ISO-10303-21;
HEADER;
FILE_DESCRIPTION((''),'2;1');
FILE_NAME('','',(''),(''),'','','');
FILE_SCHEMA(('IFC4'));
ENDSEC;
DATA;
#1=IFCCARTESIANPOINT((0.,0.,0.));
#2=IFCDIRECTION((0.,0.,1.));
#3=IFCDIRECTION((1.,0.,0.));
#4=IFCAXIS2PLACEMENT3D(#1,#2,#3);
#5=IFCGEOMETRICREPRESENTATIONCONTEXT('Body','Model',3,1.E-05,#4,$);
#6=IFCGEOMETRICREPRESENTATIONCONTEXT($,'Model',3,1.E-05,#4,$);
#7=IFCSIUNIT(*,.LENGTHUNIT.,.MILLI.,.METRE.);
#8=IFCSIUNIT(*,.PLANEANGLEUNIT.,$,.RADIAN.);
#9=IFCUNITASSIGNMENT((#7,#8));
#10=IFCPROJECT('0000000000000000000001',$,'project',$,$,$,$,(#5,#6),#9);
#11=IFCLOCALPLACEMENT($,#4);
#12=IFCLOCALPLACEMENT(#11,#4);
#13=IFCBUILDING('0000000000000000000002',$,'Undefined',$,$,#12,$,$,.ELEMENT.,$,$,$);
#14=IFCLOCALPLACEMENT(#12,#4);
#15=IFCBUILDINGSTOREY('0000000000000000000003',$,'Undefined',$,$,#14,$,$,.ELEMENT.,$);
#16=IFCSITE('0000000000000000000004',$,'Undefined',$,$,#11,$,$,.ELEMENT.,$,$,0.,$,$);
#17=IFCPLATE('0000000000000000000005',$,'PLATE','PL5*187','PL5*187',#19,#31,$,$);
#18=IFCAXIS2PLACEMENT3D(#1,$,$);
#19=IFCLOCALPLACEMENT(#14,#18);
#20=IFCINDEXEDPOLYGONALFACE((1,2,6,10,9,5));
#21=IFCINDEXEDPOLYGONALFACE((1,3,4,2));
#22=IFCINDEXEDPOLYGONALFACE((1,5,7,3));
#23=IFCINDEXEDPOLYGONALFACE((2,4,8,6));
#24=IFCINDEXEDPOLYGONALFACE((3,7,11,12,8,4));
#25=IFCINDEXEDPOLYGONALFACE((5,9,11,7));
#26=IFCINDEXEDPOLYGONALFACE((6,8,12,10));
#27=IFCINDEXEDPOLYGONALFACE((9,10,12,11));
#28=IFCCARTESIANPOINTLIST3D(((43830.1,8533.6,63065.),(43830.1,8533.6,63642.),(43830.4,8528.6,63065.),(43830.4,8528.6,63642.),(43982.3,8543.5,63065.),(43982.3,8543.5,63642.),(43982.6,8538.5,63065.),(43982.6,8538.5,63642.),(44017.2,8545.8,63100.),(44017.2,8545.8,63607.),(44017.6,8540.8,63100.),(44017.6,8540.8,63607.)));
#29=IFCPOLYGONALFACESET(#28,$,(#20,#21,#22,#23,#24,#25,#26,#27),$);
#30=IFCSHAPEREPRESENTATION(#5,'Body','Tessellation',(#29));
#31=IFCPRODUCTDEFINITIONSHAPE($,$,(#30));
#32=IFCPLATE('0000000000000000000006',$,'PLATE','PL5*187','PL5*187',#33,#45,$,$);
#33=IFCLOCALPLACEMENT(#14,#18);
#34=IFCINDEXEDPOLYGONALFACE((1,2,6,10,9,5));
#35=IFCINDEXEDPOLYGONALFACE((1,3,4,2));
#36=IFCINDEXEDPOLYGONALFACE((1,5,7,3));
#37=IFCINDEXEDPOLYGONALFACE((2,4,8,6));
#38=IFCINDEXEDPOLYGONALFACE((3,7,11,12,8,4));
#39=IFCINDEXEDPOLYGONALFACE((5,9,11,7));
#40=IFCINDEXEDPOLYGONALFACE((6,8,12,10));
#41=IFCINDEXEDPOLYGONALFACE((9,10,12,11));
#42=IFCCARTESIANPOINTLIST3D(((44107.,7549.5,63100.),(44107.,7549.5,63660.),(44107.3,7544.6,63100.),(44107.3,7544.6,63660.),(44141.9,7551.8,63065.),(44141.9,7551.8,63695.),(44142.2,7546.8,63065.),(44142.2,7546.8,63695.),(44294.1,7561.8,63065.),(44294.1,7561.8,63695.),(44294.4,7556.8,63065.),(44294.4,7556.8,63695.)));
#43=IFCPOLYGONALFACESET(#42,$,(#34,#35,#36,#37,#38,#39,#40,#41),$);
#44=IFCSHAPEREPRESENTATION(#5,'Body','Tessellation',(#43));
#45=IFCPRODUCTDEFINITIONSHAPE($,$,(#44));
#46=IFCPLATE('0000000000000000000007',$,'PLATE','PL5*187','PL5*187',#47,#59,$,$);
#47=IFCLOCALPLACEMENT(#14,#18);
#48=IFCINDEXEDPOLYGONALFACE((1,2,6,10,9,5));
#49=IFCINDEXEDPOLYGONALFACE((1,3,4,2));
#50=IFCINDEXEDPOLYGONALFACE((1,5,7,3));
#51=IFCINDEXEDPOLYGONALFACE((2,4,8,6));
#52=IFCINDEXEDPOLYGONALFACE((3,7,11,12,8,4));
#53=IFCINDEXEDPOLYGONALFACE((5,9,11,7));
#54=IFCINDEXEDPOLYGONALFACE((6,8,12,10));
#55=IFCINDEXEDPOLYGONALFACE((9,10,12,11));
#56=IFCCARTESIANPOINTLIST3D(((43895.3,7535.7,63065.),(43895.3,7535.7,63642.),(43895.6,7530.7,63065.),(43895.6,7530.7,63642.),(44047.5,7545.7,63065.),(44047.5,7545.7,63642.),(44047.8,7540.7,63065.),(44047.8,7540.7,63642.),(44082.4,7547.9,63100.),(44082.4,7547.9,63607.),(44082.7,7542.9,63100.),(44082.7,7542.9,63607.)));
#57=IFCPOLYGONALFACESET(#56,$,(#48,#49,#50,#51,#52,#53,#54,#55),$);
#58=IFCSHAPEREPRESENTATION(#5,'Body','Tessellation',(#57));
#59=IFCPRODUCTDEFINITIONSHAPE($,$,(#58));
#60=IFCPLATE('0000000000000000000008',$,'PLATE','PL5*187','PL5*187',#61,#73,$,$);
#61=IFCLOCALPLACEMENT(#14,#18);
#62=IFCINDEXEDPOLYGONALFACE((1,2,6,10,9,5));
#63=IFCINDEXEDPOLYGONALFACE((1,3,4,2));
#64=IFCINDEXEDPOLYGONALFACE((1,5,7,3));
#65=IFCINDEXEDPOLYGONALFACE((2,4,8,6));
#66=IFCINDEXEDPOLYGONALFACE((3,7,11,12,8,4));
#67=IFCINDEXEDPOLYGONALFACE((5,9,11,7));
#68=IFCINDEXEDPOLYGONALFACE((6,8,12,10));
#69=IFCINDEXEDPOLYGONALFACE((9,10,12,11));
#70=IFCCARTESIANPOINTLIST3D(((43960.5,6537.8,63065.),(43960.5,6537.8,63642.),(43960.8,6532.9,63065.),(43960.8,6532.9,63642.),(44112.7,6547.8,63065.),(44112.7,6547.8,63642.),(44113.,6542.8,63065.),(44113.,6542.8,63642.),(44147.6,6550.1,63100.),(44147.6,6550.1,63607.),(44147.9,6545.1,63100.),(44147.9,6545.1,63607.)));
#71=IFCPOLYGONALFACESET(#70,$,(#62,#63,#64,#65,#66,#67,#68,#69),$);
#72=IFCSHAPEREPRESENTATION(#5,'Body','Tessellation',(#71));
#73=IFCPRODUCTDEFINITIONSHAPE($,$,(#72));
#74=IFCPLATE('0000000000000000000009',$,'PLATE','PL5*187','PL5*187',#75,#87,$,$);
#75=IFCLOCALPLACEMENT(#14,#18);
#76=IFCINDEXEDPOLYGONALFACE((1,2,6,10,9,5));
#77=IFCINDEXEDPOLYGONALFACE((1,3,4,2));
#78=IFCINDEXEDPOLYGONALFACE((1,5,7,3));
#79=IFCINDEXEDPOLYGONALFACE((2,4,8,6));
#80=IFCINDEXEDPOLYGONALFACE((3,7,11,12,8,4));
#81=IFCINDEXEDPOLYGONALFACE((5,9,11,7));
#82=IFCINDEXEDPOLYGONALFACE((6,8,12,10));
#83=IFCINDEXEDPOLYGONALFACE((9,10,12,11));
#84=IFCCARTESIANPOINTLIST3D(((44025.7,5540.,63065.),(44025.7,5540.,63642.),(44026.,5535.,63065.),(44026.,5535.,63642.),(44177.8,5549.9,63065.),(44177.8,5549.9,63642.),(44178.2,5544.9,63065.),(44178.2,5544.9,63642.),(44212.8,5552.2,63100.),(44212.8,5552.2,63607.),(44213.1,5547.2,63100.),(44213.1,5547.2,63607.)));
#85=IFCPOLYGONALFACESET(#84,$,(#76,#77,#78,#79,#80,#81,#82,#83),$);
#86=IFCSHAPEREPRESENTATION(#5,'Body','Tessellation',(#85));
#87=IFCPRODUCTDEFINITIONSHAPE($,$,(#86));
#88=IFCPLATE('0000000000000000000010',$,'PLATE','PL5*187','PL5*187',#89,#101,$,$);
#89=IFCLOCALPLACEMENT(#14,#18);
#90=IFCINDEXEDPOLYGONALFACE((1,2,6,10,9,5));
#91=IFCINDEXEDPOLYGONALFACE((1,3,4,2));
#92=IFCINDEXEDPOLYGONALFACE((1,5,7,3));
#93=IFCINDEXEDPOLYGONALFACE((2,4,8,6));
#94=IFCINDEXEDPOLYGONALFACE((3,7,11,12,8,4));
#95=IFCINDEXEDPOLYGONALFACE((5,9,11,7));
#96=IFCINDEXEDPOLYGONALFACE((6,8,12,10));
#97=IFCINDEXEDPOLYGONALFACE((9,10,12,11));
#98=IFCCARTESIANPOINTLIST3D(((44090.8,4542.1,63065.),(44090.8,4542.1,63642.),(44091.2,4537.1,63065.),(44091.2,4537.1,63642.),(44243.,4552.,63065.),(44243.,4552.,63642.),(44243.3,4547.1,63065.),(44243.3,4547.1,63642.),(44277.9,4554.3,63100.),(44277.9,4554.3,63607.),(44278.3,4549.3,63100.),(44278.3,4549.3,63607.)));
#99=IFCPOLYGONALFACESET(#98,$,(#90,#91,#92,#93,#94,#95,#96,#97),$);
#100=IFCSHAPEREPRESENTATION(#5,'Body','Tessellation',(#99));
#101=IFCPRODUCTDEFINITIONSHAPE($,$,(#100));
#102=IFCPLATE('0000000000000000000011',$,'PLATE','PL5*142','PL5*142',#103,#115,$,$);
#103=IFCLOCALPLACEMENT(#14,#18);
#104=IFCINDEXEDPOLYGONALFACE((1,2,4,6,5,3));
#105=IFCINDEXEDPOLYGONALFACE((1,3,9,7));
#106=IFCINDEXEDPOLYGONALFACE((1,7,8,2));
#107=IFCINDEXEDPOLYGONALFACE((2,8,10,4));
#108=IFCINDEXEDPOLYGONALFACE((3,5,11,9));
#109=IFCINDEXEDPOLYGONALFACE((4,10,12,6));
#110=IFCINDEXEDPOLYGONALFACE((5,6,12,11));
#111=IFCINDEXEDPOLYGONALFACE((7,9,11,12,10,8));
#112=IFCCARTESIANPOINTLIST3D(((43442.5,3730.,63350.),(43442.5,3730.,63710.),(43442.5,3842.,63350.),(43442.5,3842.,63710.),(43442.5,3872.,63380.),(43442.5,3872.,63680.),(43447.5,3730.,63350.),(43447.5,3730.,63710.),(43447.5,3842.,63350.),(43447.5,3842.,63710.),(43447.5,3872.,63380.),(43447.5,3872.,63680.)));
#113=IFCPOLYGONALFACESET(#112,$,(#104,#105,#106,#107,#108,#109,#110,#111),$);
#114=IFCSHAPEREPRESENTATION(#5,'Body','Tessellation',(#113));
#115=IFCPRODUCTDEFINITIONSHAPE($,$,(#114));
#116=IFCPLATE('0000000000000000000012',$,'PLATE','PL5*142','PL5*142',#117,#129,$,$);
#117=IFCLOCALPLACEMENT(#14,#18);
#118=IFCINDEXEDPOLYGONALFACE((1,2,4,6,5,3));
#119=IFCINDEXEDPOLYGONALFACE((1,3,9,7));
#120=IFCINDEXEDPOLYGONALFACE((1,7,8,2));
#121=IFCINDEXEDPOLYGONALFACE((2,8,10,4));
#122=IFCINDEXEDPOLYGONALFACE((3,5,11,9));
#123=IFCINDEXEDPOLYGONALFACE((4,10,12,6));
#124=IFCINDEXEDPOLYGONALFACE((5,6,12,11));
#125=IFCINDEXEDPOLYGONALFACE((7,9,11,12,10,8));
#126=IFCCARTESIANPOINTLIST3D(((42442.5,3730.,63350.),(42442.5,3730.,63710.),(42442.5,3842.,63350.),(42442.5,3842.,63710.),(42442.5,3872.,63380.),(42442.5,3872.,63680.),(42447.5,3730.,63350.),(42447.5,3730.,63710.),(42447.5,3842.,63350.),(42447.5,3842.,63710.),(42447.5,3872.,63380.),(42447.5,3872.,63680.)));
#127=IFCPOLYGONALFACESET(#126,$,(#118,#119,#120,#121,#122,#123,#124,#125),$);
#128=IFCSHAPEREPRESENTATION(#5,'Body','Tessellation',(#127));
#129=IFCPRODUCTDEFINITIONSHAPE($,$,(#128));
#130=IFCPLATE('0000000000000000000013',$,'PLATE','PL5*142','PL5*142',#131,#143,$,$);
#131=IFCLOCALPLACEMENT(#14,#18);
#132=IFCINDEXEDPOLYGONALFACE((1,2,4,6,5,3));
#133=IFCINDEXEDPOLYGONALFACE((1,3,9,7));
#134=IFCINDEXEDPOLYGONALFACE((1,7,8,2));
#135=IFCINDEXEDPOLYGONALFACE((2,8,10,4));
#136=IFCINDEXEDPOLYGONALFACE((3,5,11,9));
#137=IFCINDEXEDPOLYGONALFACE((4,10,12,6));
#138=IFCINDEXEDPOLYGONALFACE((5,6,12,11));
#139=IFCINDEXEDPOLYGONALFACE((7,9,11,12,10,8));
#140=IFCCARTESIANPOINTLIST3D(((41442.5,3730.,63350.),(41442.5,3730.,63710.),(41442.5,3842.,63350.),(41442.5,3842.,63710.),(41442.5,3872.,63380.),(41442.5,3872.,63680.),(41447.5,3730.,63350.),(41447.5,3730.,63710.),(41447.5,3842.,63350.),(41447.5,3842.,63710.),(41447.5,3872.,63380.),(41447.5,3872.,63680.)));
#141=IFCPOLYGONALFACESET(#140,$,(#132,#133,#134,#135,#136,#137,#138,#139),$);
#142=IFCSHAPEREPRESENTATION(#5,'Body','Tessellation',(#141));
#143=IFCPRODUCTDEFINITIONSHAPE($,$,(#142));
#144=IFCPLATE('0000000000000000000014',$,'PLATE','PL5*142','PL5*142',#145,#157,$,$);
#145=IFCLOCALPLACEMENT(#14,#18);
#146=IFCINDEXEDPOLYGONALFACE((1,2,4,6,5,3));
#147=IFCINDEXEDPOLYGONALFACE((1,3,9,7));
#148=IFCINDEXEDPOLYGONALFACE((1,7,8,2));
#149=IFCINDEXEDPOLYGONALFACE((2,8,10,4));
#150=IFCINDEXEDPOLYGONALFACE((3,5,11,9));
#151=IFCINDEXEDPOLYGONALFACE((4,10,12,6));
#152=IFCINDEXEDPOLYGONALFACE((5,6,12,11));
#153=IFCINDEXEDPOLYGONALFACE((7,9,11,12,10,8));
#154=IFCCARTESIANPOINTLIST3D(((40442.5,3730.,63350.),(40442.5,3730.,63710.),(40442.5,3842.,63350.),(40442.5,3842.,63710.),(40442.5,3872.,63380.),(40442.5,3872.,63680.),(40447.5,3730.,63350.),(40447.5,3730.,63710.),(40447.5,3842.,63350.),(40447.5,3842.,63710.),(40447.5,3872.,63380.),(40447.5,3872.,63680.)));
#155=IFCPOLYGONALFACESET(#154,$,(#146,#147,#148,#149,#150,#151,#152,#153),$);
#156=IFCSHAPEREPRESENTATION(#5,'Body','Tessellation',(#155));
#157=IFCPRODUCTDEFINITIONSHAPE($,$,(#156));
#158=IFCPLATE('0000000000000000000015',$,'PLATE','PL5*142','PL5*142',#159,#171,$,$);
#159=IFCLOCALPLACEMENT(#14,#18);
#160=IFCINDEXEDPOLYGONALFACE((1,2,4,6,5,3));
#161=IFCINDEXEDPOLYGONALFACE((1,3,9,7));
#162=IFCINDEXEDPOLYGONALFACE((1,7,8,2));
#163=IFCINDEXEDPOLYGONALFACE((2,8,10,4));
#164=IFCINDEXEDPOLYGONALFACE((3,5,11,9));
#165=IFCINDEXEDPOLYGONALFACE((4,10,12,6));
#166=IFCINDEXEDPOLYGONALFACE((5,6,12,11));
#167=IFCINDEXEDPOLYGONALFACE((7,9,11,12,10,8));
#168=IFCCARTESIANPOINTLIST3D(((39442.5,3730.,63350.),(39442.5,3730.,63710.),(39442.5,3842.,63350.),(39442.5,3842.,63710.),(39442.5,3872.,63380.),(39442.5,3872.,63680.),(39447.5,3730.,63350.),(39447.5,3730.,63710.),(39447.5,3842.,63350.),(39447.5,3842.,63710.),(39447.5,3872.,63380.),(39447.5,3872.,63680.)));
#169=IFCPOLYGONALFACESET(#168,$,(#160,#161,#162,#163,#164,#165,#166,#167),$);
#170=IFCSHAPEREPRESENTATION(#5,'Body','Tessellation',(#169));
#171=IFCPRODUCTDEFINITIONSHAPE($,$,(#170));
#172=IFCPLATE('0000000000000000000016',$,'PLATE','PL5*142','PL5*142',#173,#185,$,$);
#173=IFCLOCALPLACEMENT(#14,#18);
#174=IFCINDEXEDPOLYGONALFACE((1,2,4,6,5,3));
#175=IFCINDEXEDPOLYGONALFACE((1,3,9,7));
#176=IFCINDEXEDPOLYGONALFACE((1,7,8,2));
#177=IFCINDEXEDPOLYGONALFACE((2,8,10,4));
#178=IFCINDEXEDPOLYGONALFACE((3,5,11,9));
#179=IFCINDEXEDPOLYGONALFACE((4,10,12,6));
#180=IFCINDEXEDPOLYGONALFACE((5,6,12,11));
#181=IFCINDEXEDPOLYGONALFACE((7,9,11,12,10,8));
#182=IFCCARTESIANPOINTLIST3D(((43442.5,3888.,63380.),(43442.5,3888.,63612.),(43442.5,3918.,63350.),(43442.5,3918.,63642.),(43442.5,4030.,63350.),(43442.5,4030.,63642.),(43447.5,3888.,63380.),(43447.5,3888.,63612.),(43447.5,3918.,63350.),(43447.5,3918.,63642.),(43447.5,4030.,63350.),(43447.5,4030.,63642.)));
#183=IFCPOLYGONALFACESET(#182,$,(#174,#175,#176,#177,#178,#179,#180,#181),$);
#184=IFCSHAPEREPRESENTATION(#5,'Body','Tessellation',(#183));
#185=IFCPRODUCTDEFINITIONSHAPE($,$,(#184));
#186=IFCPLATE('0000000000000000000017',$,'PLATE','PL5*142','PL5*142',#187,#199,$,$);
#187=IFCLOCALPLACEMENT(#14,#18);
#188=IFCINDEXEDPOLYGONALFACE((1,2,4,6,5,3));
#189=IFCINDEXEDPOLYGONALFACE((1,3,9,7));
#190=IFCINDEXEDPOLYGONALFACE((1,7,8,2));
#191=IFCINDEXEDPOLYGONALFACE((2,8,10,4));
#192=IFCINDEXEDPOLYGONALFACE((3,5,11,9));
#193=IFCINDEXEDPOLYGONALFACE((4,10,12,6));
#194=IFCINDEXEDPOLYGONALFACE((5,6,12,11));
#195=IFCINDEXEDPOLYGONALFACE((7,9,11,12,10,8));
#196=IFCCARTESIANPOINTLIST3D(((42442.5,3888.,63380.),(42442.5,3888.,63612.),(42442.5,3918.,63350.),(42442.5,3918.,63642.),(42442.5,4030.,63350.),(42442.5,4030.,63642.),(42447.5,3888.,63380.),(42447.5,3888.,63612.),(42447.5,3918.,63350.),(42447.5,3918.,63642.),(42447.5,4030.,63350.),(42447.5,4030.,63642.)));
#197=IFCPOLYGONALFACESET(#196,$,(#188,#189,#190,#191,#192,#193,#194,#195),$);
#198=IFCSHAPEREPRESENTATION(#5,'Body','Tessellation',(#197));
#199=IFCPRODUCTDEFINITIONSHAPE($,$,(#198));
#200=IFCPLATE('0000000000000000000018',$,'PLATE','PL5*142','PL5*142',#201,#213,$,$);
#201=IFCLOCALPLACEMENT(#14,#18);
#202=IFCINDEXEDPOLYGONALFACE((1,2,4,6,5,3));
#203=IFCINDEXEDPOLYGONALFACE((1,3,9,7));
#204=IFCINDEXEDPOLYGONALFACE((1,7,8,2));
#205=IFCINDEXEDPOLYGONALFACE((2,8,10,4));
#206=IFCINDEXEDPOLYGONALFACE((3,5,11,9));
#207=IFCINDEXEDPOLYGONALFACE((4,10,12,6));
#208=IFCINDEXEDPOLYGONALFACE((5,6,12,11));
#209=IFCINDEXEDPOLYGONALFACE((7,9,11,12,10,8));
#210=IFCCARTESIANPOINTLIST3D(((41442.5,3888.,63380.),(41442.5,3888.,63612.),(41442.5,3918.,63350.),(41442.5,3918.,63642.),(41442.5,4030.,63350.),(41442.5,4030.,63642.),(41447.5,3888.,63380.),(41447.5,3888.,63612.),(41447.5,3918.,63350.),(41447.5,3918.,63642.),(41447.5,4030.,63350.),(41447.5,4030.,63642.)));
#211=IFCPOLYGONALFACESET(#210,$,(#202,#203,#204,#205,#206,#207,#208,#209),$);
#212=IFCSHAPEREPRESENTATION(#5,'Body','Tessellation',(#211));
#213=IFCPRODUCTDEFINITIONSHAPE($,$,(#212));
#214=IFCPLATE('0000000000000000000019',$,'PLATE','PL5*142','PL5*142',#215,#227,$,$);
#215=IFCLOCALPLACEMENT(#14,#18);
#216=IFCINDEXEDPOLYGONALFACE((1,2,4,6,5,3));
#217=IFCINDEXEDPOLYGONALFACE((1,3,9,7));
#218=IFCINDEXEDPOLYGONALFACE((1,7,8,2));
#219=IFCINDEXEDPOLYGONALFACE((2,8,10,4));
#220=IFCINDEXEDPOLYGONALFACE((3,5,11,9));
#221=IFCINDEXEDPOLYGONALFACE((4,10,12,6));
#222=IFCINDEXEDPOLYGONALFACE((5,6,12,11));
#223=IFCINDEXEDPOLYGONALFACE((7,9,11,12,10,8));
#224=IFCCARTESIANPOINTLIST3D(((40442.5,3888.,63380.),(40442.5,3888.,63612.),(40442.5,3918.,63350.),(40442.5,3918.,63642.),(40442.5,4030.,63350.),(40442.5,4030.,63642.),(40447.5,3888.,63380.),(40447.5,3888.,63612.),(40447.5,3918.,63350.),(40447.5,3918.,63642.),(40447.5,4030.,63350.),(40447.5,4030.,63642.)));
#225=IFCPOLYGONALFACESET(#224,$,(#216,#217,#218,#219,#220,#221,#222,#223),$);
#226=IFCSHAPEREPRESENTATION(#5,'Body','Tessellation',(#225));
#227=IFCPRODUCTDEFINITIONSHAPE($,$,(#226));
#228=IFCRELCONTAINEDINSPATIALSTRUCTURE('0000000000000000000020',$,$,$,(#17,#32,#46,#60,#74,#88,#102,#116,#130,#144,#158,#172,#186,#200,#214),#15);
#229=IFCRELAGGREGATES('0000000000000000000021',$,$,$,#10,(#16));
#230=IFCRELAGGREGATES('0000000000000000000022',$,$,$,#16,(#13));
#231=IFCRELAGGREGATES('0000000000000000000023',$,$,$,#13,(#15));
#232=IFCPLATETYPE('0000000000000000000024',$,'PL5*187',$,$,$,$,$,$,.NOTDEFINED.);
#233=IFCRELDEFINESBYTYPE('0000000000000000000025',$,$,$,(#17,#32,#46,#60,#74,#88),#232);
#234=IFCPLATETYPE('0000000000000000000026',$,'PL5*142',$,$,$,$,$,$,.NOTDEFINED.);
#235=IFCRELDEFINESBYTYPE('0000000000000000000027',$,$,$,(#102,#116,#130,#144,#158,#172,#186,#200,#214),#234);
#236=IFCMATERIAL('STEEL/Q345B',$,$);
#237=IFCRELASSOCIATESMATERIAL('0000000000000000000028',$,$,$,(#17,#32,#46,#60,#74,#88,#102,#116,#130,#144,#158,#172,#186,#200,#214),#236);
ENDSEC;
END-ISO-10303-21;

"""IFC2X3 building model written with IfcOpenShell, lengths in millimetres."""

from ifc_helpers import new_model, si_unit, frame, origin_with_axes, place, context, project, spatial, polyline, outline, extrude, material, type_object, element, save


model = new_model("IFC2X3")

# Units and contexts
model_context_1 = context("Model", 3, precision=1e-05, world=origin_with_axes(), identifier="Body")
model_context_2 = context("Model", 3, precision=1e-05, world=origin_with_axes())
ifc_project = project(units=[si_unit("LENGTHUNIT", "METRE", prefix="MILLI"), si_unit("PLANEANGLEUNIT", "RADIAN")], contexts=[model_context_1, model_context_2])

# Site, building, storey
site_placement = place(None, origin_with_axes())
site = spatial("IfcSite", under=ifc_project, at=site_placement, Name="Undefined", CompositionType="ELEMENT", RefElevation=0.0)
building_placement = place(site_placement, origin_with_axes())
building = spatial("IfcBuilding", under=site, at=building_placement, Name="Undefined", CompositionType="ELEMENT")
storey_placement = place(building_placement, origin_with_axes())
storey = spatial("IfcBuildingStorey", under=building, at=storey_placement, Name="Undefined", CompositionType="ELEMENT")

# Shared definitions
ifc_material_1 = material(Name="STEEL/Q345B")

# Plates
plate_type_1 = type_object("IfcPlateType", Name="PL5*187", PredefinedType="NOTDEFINED")
plate_1_placement = place(storey_placement, frame((43830.3, 8531.1, 63642.0), z_axis=(-0.065184, 0.997873, 0.0), x_axis=(0.997873, 0.065184, 0.0)))
element("IfcPlate", 1, at=plate_1_placement, inside=storey, type_object=plate_type_1, material=ifc_material_1, Name="PLATE", Description="PL5*187", ObjectType="PL5*187", context=model_context_1, shape_type="SweptSolid", body=[
    extrude(outline(polyline([(0.0, 0.0), (152.5, 0.0), (187.5, 35.0), (187.5, 542.0), (152.5, 577.0), (0.0, 577.0), (0.0, 0.0)])), frame((0.0, 0.0, -2.5), z_axis=(0.0, 0.0, 1.0), x_axis=(1.0, 0.0, 0.0)), (0.0, 0.0, 1.0), 5.0),
])
plate_2_placement = place(storey_placement, frame((44294.3, 7559.3, 63695.0), z_axis=(0.065171, -0.997874, 0.0), x_axis=(-0.997874, -0.065171, 0.0)))
element("IfcPlate", 2, at=plate_2_placement, inside=storey, type_object=plate_type_1, material=ifc_material_1, Name="PLATE", Description="PL5*187", ObjectType="PL5*187", context=model_context_1, shape_type="SweptSolid", body=[
    extrude(outline(polyline([(0.0, 0.0), (152.5, 0.0), (187.5, 35.0), (187.5, 595.0), (152.5, 630.0), (0.0, 630.0), (0.0, 0.0)])), frame((0.0, 0.0, -2.5), z_axis=(0.0, 0.0, 1.0), x_axis=(1.0, 0.0, 0.0)), (0.0, 0.0, 1.0), 5.0),
])
for number, where, z_axis, x_axis, name in (
    (3, (43895.5, 7533.2, 63642.0), (-0.065184, 0.997873, 0.0), (0.997873, 0.065184, 0.0), "PLATE"),
    (4, (43960.6, 6535.4, 63642.0), (-0.065184, 0.997873, 0.0), (0.997873, 0.065184, 0.0), "PLATE"),
    (5, (44025.8, 5537.5, 63642.0), (-0.065184, 0.997873, 0.0), (0.997873, 0.065184, 0.0), "PLATE"),
    (6, (44091.0, 4539.6, 63642.0), (-0.065184, 0.997873, 0.0), (0.997873, 0.065184, 0.0), "PLATE"),
):
    element("IfcPlate", number, at=place(storey_placement, frame(where, z_axis=z_axis, x_axis=x_axis)), inside=storey, type_object=plate_type_1, material=ifc_material_1, Name=name, Description="PL5*187", ObjectType="PL5*187", context=model_context_1, shape_type="SweptSolid", body=[
        extrude(outline(polyline([(0.0, 0.0), (152.5, 0.0), (187.5, 35.0), (187.5, 542.0), (152.5, 577.0), (0.0, 577.0), (0.0, 0.0)])), frame((0.0, 0.0, -2.5), z_axis=(0.0, 0.0, 1.0), x_axis=(1.0, 0.0, 0.0)), (0.0, 0.0, 1.0), 5.0),
    ])
plate_type_2 = type_object("IfcPlateType", Name="PL5*142", PredefinedType="NOTDEFINED")
for number, where, z_axis, x_axis, name in (
    (7, (43445.0, 3730.0, 63710.0), (-1.0, 0.0, 0.0), (0.0, 1.0, 0.0), "PLATE"),
    (8, (42445.0, 3730.0, 63710.0), (-1.0, 0.0, 0.0), (0.0, 1.0, 0.0), "PLATE"),
    (9, (41445.0, 3730.0, 63710.0), (-1.0, 0.0, 0.0), (0.0, 1.0, 0.0), "PLATE"),
    (10, (40445.0, 3730.0, 63710.0), (-1.0, 0.0, 0.0), (0.0, 1.0, 0.0), "PLATE"),
    (11, (39445.0, 3730.0, 63710.0), (-1.0, 0.0, 0.0), (0.0, 1.0, 0.0), "PLATE"),
):
    element("IfcPlate", number, at=place(storey_placement, frame(where, z_axis=z_axis, x_axis=x_axis)), inside=storey, type_object=plate_type_2, material=ifc_material_1, Name=name, Description="PL5*142", ObjectType="PL5*142", context=model_context_1, shape_type="SweptSolid", body=[
        extrude(outline(polyline([(0.0, 0.0), (112.0, 0.0), (142.0, 30.0), (142.0, 330.0), (112.0, 360.0), (0.0, 360.0), (0.0, 0.0)])), frame((0.0, 0.0, -2.5), z_axis=(0.0, 0.0, 1.0), x_axis=(1.0, 0.0, 0.0)), (0.0, 0.0, 1.0), 5.0),
    ])
for number, where, z_axis, x_axis, name in (
    (12, (43445.0, 4030.0, 63642.0), (1.0, 0.0, 0.0), (0.0, -1.0, 0.0), "PLATE"),
    (13, (42445.0, 4030.0, 63642.0), (1.0, 0.0, 0.0), (0.0, -1.0, 0.0), "PLATE"),
    (14, (41445.0, 4030.0, 63642.0), (1.0, 0.0, 0.0), (0.0, -1.0, 0.0), "PLATE"),
    (15, (40445.0, 4030.0, 63642.0), (1.0, 0.0, 0.0), (0.0, -1.0, 0.0), "PLATE"),
):
    element("IfcPlate", number, at=place(storey_placement, frame(where, z_axis=z_axis, x_axis=x_axis)), inside=storey, type_object=plate_type_2, material=ifc_material_1, Name=name, Description="PL5*142", ObjectType="PL5*142", context=model_context_1, shape_type="SweptSolid", body=[
        extrude(outline(polyline([(0.0, 0.0), (112.0, 0.0), (142.0, 30.0), (142.0, 262.0), (112.0, 292.0), (0.0, 292.0), (0.0, 0.0)])), frame((0.0, 0.0, -2.5), z_axis=(0.0, 0.0, 1.0), x_axis=(1.0, 0.0, 0.0)), (0.0, 0.0, 1.0), 5.0),
    ])

save(model, "model.ifc")
